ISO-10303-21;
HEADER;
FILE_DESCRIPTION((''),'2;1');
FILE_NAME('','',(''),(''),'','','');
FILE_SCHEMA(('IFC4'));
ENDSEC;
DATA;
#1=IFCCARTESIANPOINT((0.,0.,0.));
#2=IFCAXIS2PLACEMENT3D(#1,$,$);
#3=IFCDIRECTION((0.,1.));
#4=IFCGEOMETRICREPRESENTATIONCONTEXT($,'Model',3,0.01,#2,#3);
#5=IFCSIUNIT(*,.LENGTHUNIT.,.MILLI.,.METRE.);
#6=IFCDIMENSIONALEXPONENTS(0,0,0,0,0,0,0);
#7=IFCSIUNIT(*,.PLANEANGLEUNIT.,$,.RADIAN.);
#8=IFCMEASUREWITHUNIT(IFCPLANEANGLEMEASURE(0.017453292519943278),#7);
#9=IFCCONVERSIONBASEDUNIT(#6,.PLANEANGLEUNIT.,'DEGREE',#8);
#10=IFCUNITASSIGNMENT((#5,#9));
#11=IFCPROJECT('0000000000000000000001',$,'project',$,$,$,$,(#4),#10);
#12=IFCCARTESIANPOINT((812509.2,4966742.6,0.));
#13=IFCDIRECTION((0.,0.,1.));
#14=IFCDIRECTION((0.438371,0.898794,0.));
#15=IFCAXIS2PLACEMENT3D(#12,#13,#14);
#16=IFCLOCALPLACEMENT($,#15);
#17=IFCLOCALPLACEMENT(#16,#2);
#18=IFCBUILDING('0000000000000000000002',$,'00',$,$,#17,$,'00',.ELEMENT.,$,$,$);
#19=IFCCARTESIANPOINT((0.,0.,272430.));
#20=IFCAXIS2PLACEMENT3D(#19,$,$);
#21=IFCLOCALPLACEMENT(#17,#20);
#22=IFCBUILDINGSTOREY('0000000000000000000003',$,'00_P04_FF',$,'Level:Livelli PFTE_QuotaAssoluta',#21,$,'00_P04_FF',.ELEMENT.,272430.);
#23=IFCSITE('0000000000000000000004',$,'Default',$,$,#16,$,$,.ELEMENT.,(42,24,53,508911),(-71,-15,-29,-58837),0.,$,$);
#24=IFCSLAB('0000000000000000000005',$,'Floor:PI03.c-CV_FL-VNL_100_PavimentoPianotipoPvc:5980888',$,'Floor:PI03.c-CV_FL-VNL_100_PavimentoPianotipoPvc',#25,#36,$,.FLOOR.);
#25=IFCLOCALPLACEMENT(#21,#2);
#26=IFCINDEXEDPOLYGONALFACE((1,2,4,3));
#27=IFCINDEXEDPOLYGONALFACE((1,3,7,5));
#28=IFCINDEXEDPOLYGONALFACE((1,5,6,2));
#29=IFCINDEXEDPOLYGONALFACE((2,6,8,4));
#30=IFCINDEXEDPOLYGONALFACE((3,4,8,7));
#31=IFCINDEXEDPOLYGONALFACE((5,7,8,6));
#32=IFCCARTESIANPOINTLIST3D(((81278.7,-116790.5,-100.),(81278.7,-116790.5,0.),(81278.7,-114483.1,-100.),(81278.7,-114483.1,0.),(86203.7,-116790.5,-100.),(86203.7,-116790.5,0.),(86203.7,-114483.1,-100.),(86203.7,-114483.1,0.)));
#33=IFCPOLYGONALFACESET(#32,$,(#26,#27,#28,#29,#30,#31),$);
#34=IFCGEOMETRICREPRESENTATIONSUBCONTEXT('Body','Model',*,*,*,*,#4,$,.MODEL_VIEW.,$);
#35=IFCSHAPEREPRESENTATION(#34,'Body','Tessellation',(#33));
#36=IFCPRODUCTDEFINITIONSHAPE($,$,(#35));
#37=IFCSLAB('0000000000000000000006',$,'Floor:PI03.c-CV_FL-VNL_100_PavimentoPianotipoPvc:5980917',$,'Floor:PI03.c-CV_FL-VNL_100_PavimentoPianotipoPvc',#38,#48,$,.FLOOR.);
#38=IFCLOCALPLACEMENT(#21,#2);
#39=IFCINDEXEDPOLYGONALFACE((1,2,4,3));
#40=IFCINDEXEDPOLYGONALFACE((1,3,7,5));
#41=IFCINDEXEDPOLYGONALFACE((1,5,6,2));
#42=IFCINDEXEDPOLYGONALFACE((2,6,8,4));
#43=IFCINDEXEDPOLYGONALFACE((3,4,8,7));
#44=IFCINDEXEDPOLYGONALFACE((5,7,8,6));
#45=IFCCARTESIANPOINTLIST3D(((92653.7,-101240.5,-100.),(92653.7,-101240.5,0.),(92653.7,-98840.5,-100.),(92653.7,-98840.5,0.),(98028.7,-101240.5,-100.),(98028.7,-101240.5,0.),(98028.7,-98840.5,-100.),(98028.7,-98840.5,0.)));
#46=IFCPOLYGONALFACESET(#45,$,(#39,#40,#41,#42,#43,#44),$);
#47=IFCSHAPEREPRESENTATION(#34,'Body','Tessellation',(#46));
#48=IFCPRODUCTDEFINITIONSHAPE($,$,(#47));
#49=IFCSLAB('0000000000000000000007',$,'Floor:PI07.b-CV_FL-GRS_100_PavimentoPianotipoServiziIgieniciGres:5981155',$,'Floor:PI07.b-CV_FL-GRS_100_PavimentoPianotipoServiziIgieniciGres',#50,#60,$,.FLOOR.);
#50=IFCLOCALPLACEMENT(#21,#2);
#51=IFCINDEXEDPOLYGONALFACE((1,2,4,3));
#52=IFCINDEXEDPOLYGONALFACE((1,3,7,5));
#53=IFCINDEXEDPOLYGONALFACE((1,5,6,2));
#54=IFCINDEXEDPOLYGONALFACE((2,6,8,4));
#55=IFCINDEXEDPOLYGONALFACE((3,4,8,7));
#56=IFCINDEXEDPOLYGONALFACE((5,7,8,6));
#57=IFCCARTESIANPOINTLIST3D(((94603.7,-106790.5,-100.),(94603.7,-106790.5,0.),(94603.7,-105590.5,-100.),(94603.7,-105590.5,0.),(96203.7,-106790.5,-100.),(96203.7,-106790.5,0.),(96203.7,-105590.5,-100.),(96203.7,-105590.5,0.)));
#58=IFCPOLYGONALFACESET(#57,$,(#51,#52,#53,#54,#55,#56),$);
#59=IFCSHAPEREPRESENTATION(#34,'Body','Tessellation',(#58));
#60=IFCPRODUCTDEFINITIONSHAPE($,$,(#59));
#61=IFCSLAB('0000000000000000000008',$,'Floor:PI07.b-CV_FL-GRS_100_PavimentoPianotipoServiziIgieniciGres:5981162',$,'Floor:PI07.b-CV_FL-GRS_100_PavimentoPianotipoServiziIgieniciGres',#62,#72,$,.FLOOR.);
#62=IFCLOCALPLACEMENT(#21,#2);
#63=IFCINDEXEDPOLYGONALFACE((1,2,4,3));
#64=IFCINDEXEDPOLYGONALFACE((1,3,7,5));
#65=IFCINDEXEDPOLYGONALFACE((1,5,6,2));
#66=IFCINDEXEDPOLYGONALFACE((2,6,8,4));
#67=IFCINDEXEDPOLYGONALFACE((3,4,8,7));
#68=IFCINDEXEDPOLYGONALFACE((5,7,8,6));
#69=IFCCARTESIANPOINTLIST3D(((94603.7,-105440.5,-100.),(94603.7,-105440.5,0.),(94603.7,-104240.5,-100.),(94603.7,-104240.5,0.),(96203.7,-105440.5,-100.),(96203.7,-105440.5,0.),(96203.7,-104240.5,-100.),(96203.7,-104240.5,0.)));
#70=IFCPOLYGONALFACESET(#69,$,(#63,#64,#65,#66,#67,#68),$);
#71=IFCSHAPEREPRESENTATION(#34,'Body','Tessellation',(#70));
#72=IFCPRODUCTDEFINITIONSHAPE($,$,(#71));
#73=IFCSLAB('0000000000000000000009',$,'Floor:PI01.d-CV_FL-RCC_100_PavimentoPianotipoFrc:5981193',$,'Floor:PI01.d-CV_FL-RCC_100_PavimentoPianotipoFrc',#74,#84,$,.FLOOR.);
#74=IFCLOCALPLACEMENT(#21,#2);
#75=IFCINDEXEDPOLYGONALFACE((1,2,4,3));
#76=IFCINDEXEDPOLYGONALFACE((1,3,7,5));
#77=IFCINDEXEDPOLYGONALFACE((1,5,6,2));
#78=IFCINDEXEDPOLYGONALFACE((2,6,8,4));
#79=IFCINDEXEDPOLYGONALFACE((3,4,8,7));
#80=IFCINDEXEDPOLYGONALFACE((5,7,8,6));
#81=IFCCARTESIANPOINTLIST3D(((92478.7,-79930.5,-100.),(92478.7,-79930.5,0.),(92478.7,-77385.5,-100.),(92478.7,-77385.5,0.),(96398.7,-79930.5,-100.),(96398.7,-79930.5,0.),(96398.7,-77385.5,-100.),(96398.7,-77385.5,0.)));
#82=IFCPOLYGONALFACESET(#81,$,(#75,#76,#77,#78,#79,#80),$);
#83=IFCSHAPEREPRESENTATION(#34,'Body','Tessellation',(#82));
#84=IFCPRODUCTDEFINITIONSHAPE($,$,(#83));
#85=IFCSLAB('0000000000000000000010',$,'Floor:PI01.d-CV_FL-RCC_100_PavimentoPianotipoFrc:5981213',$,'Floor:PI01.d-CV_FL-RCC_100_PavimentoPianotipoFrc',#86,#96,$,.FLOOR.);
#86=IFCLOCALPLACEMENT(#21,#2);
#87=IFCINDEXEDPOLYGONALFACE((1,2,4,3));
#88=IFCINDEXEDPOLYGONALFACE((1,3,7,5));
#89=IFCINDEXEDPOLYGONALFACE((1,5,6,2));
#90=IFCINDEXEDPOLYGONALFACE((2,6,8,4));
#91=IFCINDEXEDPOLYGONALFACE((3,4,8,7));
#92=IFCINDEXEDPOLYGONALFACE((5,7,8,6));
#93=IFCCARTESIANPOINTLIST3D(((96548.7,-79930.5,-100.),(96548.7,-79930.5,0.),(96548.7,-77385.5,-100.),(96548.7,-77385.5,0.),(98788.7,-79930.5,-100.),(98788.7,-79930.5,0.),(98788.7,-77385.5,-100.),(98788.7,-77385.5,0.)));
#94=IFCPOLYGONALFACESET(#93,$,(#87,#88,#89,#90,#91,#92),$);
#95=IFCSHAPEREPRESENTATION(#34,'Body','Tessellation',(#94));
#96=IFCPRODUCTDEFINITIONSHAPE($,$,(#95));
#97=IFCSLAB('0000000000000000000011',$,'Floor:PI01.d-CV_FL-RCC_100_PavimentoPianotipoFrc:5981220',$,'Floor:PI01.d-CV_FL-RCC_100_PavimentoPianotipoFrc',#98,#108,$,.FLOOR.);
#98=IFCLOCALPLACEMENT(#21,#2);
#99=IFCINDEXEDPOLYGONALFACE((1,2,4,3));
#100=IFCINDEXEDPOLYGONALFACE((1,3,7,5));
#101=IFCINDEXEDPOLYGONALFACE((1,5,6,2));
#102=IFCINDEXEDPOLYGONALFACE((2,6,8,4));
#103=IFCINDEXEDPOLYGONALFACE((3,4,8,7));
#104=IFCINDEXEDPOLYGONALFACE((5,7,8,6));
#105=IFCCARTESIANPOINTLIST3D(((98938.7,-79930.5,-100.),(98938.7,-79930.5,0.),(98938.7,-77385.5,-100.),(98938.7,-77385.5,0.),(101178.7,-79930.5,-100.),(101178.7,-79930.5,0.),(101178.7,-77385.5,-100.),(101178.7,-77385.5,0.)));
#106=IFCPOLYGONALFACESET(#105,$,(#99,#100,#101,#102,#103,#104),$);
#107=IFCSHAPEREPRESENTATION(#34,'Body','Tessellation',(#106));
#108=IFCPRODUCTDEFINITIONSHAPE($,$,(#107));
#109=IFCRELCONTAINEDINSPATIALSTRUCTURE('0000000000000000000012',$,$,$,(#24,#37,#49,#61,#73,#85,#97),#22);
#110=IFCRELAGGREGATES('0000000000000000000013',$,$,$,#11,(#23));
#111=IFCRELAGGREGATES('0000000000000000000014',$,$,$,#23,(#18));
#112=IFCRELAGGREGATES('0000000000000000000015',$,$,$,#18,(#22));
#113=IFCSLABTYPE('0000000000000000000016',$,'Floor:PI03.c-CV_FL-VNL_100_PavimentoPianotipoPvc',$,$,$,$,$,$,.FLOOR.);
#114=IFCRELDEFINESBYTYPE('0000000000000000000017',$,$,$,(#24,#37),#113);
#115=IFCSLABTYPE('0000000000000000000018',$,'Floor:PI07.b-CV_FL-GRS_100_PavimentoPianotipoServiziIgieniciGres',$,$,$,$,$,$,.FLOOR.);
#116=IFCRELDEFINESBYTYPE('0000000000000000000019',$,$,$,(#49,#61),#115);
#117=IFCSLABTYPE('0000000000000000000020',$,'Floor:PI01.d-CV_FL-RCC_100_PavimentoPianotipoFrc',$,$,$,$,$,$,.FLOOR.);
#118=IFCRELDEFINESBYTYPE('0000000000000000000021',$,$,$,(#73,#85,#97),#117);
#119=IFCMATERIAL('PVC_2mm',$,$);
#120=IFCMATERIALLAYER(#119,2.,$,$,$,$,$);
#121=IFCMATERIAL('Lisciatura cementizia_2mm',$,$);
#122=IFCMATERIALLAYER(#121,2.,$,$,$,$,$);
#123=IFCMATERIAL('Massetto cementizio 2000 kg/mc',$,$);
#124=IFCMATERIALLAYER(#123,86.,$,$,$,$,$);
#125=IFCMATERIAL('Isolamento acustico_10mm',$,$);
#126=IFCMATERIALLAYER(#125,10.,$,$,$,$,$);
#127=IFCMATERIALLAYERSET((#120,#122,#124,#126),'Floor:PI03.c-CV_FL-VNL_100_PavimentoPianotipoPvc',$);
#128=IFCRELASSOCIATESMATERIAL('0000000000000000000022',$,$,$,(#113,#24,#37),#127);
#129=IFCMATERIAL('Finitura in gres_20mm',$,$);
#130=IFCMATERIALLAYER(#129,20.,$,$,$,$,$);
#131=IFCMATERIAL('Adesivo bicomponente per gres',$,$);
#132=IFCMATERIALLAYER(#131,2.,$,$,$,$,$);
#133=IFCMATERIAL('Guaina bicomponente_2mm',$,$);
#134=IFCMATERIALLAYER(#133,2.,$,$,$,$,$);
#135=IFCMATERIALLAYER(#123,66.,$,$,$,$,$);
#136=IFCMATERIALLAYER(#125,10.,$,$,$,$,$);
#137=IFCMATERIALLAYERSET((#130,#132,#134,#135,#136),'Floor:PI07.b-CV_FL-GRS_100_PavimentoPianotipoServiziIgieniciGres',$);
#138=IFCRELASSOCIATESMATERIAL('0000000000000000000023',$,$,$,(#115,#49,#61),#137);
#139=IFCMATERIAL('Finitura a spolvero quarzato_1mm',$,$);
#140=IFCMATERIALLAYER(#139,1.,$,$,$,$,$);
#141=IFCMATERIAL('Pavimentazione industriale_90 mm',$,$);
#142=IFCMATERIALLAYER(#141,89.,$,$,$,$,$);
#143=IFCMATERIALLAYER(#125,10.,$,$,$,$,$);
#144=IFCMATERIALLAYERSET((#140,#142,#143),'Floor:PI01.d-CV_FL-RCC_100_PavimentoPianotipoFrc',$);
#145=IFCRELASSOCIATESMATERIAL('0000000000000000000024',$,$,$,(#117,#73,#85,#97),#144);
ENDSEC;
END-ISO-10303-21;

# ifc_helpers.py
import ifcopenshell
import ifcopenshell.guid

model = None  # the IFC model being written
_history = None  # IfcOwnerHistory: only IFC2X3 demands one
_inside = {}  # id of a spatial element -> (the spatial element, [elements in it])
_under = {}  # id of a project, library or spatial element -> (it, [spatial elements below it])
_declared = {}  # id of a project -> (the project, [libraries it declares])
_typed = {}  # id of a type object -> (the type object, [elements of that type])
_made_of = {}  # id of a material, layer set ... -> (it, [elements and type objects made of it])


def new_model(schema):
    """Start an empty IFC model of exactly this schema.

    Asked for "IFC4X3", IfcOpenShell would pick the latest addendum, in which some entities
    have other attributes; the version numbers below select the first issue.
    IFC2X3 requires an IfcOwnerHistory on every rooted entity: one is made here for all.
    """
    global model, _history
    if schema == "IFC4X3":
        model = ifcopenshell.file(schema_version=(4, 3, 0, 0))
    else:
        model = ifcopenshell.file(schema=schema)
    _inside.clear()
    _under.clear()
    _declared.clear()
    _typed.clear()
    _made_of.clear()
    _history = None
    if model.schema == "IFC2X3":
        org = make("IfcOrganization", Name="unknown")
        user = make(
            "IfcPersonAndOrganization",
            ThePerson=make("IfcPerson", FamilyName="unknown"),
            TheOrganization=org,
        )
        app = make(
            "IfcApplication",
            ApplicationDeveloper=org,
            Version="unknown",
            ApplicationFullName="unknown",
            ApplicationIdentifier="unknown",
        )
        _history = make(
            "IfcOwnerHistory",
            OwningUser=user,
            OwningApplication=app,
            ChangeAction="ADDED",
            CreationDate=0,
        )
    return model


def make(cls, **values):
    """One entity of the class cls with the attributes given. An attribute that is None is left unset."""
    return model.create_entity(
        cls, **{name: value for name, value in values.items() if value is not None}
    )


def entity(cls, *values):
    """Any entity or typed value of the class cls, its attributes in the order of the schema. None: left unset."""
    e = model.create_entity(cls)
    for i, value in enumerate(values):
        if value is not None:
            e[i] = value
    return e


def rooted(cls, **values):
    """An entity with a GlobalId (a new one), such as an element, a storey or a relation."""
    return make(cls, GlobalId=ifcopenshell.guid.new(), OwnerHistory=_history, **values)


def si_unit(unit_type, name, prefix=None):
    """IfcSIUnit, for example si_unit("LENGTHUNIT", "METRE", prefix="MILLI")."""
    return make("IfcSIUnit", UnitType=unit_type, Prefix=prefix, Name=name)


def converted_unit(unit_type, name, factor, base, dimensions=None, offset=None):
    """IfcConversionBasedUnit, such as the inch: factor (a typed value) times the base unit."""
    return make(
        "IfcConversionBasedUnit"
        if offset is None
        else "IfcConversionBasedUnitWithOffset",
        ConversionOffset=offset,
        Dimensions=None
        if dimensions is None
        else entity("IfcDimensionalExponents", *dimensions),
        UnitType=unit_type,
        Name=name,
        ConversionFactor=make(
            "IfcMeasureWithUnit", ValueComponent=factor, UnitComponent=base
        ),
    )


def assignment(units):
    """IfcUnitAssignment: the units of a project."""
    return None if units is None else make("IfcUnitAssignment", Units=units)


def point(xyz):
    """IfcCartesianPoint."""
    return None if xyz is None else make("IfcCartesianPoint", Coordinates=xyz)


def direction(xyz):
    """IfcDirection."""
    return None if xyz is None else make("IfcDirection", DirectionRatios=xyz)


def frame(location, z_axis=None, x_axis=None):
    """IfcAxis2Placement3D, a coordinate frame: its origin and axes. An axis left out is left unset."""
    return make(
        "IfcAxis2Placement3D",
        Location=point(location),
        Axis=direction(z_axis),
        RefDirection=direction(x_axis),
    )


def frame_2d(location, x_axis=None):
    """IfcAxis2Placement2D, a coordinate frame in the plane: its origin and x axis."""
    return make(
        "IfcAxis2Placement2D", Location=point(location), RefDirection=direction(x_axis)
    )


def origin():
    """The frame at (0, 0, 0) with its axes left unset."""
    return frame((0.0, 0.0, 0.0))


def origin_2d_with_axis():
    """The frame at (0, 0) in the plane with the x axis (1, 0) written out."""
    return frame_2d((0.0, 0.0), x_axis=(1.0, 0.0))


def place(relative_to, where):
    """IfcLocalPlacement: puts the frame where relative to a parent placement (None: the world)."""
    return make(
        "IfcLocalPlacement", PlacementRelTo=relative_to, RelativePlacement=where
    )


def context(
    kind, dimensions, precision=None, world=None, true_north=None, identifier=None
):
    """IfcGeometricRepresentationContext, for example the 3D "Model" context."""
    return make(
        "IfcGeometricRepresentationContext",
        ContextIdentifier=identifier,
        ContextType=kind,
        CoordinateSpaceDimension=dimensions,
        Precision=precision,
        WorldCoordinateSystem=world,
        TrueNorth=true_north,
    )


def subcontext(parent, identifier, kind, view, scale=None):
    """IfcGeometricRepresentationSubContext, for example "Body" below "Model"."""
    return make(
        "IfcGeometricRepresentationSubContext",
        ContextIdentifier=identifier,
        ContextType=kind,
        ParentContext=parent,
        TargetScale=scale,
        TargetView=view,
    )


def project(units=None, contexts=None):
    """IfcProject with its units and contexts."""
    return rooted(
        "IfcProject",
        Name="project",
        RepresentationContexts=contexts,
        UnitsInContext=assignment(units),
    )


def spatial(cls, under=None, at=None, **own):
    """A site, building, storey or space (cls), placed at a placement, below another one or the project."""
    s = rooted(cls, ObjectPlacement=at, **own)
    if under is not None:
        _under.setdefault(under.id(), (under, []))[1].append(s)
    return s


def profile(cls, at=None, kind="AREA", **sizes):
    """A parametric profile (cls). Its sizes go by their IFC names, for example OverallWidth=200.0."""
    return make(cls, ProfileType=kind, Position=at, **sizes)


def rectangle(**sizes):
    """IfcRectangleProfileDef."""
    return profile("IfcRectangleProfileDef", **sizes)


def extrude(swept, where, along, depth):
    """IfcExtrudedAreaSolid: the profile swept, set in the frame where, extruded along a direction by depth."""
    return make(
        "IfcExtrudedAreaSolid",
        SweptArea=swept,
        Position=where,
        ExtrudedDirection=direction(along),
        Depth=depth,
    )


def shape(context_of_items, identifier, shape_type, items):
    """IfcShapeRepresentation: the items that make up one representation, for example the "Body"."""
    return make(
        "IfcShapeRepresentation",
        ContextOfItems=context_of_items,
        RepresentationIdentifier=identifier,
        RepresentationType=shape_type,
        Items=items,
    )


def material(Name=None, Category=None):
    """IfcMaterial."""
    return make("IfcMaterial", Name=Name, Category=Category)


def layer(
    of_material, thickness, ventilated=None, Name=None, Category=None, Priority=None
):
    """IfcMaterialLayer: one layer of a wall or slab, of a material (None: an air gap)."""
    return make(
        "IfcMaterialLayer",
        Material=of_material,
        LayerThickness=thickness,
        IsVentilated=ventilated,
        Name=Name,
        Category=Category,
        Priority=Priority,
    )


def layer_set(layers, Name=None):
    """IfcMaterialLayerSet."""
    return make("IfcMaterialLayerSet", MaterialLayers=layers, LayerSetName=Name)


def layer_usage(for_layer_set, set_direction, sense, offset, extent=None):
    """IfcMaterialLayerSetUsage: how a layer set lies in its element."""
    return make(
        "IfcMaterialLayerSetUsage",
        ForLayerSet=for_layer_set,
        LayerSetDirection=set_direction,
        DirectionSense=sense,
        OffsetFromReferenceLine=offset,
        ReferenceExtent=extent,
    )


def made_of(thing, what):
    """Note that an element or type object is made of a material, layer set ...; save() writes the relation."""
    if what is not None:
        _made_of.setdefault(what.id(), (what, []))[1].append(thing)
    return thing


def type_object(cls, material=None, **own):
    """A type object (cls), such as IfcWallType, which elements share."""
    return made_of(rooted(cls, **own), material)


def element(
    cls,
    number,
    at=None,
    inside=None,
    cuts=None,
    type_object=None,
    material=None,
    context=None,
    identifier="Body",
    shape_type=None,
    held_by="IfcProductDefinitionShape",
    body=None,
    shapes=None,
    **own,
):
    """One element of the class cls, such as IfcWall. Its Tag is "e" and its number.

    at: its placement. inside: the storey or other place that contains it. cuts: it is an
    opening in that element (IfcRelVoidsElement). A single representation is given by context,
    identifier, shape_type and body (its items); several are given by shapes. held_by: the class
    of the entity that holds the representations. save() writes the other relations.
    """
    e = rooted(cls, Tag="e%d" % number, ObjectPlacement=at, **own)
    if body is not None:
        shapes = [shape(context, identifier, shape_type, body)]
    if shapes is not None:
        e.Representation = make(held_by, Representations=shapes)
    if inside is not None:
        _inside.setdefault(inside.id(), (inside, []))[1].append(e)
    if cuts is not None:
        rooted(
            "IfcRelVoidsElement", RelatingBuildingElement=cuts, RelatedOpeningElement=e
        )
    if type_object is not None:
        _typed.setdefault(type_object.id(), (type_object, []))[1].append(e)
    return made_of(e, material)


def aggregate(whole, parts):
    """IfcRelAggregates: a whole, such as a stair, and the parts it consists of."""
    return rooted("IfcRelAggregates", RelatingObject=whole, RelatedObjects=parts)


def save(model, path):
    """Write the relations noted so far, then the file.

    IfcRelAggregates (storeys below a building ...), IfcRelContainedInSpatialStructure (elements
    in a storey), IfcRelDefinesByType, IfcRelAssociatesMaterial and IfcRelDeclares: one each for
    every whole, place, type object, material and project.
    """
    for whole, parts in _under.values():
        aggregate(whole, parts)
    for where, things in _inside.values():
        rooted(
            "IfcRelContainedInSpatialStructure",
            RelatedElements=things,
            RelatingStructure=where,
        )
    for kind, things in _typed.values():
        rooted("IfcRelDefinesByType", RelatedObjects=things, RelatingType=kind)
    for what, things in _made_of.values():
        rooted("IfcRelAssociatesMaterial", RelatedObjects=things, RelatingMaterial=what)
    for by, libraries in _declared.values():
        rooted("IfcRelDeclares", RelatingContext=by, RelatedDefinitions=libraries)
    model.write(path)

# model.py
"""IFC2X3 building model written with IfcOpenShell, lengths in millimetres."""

from ifc_helpers import new_model, entity, si_unit, converted_unit, direction, frame, frame_2d, origin, origin_2d_with_axis, place, context, subcontext, project, spatial, rectangle, extrude, material, layer, layer_set, layer_usage, type_object, element, save


model = new_model("IFC2X3")

# Units and contexts
model_context = context("Model", 3, precision=0.01, world=origin(), true_north=direction((0.0, 1.0)))
body_context = subcontext(model_context, "Body", "Model", "MODEL_VIEW")
ifc_project = project(units=[si_unit("LENGTHUNIT", "METRE", prefix="MILLI"), converted_unit("PLANEANGLEUNIT", "DEGREE", entity("IfcPlaneAngleMeasure", 0.017453292519943278), si_unit("PLANEANGLEUNIT", "RADIAN"), dimensions=[0, 0, 0, 0, 0, 0, 0])], contexts=[model_context])

# Site, building, storey
site_placement = place(None, frame((812509.2, 4966742.6, 0.0), z_axis=(0.0, 0.0, 1.0), x_axis=(0.438371, 0.898794, 0.0)))
site = spatial("IfcSite", under=ifc_project, at=site_placement, Name="Default", CompositionType="ELEMENT", RefLatitude=(42, 24, 53, 508911), RefLongitude=(-71, -15, -29, -58837), RefElevation=0.0)
building_placement = place(site_placement, origin())
building = spatial("IfcBuilding", under=site, at=building_placement, Name="00", LongName="00", CompositionType="ELEMENT")
storey_placement = place(building_placement, frame((0.0, 0.0, 272430.0)))
storey = spatial("IfcBuildingStorey", under=building, at=storey_placement, Name="00_P04_FF", ObjectType="Level:Livelli PFTE_QuotaAssoluta", LongName="00_P04_FF", CompositionType="ELEMENT", Elevation=272430.0)

# Slabs
ifc_material_1 = material(Name="PVC_2mm")
ifc_layer_1 = layer(ifc_material_1, 2.0)
ifc_material_2 = material(Name="Lisciatura cementizia_2mm")
ifc_layer_2 = layer(ifc_material_2, 2.0)
ifc_material_3 = material(Name="Massetto cementizio 2000 kg/mc")
ifc_layer_3 = layer(ifc_material_3, 86.0)
ifc_material_4 = material(Name="Isolamento acustico_10mm")
ifc_layer_4 = layer(ifc_material_4, 10.0)
ifc_layer_set_1 = layer_set([ifc_layer_1, ifc_layer_2, ifc_layer_3, ifc_layer_4], Name="Floor:PI03.c-CV_FL-VNL_100_PavimentoPianotipoPvc")
ifc_layer_usage_1 = layer_usage(ifc_layer_set_1, "AXIS3", "POSITIVE", 0.0)
slab_type_1 = type_object("IfcSlabType", Name="Floor:PI03.c-CV_FL-VNL_100_PavimentoPianotipoPvc", PredefinedType="FLOOR", material=ifc_layer_set_1)
slab_1_placement = place(storey_placement, origin())
element("IfcSlab", 1, at=slab_1_placement, inside=storey, type_object=slab_type_1, material=ifc_layer_usage_1, Name="Floor:PI03.c-CV_FL-VNL_100_PavimentoPianotipoPvc:5980888", ObjectType="Floor:PI03.c-CV_FL-VNL_100_PavimentoPianotipoPvc", PredefinedType="FLOOR", context=body_context, shape_type="SweptSolid", body=[
    extrude(rectangle(XDim=2307.4, YDim=4925.0, at=frame_2d((0.0, 0.0), x_axis=(1.0, 0.0))), frame((83741.2, -115636.8, 0.0), z_axis=(0.0, 0.0, -1.0), x_axis=(0.0, 1.0, 0.0)), (0.0, 0.0, 1.0), 100.0),
])
ifc_layer_usage_2 = layer_usage(ifc_layer_set_1, "AXIS3", "POSITIVE", 0.0)
slab_2_placement = place(storey_placement, origin())
element("IfcSlab", 2, at=slab_2_placement, inside=storey, type_object=slab_type_1, material=ifc_layer_usage_2, Name="Floor:PI03.c-CV_FL-VNL_100_PavimentoPianotipoPvc:5980917", ObjectType="Floor:PI03.c-CV_FL-VNL_100_PavimentoPianotipoPvc", PredefinedType="FLOOR", context=body_context, shape_type="SweptSolid", body=[
    extrude(rectangle(XDim=2400.0, YDim=5375.0, at=frame_2d((0.0, 0.0), x_axis=(1.0, 0.0))), frame((95341.2, -100040.5, 0.0), z_axis=(0.0, 0.0, -1.0), x_axis=(0.0, 1.0, 0.0)), (0.0, 0.0, 1.0), 100.0),
])

# Slabs
ifc_material_5 = material(Name="Finitura in gres_20mm")
ifc_layer_5 = layer(ifc_material_5, 20.0)
ifc_material_6 = material(Name="Adesivo bicomponente per gres")
ifc_layer_6 = layer(ifc_material_6, 2.0)
ifc_material_7 = material(Name="Guaina bicomponente_2mm")
ifc_layer_7 = layer(ifc_material_7, 2.0)
ifc_layer_8 = layer(ifc_material_3, 66.0)
ifc_layer_9 = layer(ifc_material_4, 10.0)
ifc_layer_set_2 = layer_set([ifc_layer_5, ifc_layer_6, ifc_layer_7, ifc_layer_8, ifc_layer_9], Name="Floor:PI07.b-CV_FL-GRS_100_PavimentoPianotipoServiziIgieniciGres")
ifc_layer_usage_3 = layer_usage(ifc_layer_set_2, "AXIS3", "POSITIVE", 0.0)
slab_type_2 = type_object("IfcSlabType", Name="Floor:PI07.b-CV_FL-GRS_100_PavimentoPianotipoServiziIgieniciGres", PredefinedType="FLOOR", material=ifc_layer_set_2)
slab_3_placement = place(storey_placement, origin())
element("IfcSlab", 3, at=slab_3_placement, inside=storey, type_object=slab_type_2, material=ifc_layer_usage_3, Name="Floor:PI07.b-CV_FL-GRS_100_PavimentoPianotipoServiziIgieniciGres:5981155", ObjectType="Floor:PI07.b-CV_FL-GRS_100_PavimentoPianotipoServiziIgieniciGres", PredefinedType="FLOOR", context=body_context, shape_type="SweptSolid", body=[
    extrude(rectangle(XDim=1200.0, YDim=1600.0, at=frame_2d((0.0, 0.0), x_axis=(1.0, 0.0))), frame((95403.7, -106190.5, 0.0), z_axis=(0.0, 0.0, -1.0), x_axis=(0.0, 1.0, 0.0)), (0.0, 0.0, 1.0), 100.0),
])
ifc_layer_usage_4 = layer_usage(ifc_layer_set_2, "AXIS3", "POSITIVE", 0.0)
slab_4_placement = place(storey_placement, origin())
element("IfcSlab", 4, at=slab_4_placement, inside=storey, type_object=slab_type_2, material=ifc_layer_usage_4, Name="Floor:PI07.b-CV_FL-GRS_100_PavimentoPianotipoServiziIgieniciGres:5981162", ObjectType="Floor:PI07.b-CV_FL-GRS_100_PavimentoPianotipoServiziIgieniciGres", PredefinedType="FLOOR", context=body_context, shape_type="SweptSolid", body=[
    extrude(rectangle(XDim=1200.0, YDim=1600.0, at=frame_2d((0.0, 0.0), x_axis=(1.0, 0.0))), frame((95403.7, -104840.5, 0.0), z_axis=(0.0, 0.0, -1.0), x_axis=(0.0, 1.0, 0.0)), (0.0, 0.0, 1.0), 100.0),
])
ifc_material_8 = material(Name="Finitura a spolvero quarzato_1mm")
ifc_layer_10 = layer(ifc_material_8, 1.0)
ifc_material_9 = material(Name="Pavimentazione industriale_90 mm")
ifc_layer_11 = layer(ifc_material_9, 89.0)
ifc_layer_12 = layer(ifc_material_4, 10.0)
ifc_layer_set_3 = layer_set([ifc_layer_10, ifc_layer_11, ifc_layer_12], Name="Floor:PI01.d-CV_FL-RCC_100_PavimentoPianotipoFrc")
slab_type_3 = type_object("IfcSlabType", Name="Floor:PI01.d-CV_FL-RCC_100_PavimentoPianotipoFrc", PredefinedType="FLOOR", material=ifc_layer_set_3)
ifc_layer_usage_5 = layer_usage(ifc_layer_set_3, "AXIS3", "POSITIVE", 0.0)
slab_5_placement = place(storey_placement, origin())
element("IfcSlab", 5, at=slab_5_placement, inside=storey, type_object=slab_type_3, material=ifc_layer_usage_5, Name="Floor:PI01.d-CV_FL-RCC_100_PavimentoPianotipoFrc:5981193", ObjectType="Floor:PI01.d-CV_FL-RCC_100_PavimentoPianotipoFrc", PredefinedType="FLOOR", context=body_context, shape_type="SweptSolid", body=[
    extrude(rectangle(XDim=2545.0, YDim=3920.0, at=origin_2d_with_axis()), frame((94438.7, -78658.0, 0.0), z_axis=(0.0, 0.0, -1.0), x_axis=(0.0, 1.0, 0.0)), (0.0, 0.0, 1.0), 100.0),
])
ifc_layer_usage_6 = layer_usage(ifc_layer_set_3, "AXIS3", "POSITIVE", 0.0)
slab_6_placement = place(storey_placement, origin())
element("IfcSlab", 6, at=slab_6_placement, inside=storey, type_object=slab_type_3, material=ifc_layer_usage_6, Name="Floor:PI01.d-CV_FL-RCC_100_PavimentoPianotipoFrc:5981213", ObjectType="Floor:PI01.d-CV_FL-RCC_100_PavimentoPianotipoFrc", PredefinedType="FLOOR", context=body_context, shape_type="SweptSolid", body=[
    extrude(rectangle(XDim=2545.0, YDim=2240.0, at=frame_2d((0.0, 0.0), x_axis=(1.0, 0.0))), frame((97668.7, -78658.0, 0.0), z_axis=(0.0, 0.0, -1.0), x_axis=(0.0, 1.0, 0.0)), (0.0, 0.0, 1.0), 100.0),
])
ifc_layer_usage_7 = layer_usage(ifc_layer_set_3, "AXIS3", "POSITIVE", 0.0)
slab_7_placement = place(storey_placement, origin())
element("IfcSlab", 7, at=slab_7_placement, inside=storey, type_object=slab_type_3, material=ifc_layer_usage_7, Name="Floor:PI01.d-CV_FL-RCC_100_PavimentoPianotipoFrc:5981220", ObjectType="Floor:PI01.d-CV_FL-RCC_100_PavimentoPianotipoFrc", PredefinedType="FLOOR", context=body_context, shape_type="SweptSolid", body=[
    extrude(rectangle(XDim=2545.0, YDim=2240.0, at=frame_2d((0.0, 0.0), x_axis=(1.0, 0.0))), frame((100058.7, -78658.0, 0.0), z_axis=(0.0, 0.0, -1.0), x_axis=(0.0, 1.0, 0.0)), (0.0, 0.0, 1.0), 100.0),
])

save(model, "model.ifc")
